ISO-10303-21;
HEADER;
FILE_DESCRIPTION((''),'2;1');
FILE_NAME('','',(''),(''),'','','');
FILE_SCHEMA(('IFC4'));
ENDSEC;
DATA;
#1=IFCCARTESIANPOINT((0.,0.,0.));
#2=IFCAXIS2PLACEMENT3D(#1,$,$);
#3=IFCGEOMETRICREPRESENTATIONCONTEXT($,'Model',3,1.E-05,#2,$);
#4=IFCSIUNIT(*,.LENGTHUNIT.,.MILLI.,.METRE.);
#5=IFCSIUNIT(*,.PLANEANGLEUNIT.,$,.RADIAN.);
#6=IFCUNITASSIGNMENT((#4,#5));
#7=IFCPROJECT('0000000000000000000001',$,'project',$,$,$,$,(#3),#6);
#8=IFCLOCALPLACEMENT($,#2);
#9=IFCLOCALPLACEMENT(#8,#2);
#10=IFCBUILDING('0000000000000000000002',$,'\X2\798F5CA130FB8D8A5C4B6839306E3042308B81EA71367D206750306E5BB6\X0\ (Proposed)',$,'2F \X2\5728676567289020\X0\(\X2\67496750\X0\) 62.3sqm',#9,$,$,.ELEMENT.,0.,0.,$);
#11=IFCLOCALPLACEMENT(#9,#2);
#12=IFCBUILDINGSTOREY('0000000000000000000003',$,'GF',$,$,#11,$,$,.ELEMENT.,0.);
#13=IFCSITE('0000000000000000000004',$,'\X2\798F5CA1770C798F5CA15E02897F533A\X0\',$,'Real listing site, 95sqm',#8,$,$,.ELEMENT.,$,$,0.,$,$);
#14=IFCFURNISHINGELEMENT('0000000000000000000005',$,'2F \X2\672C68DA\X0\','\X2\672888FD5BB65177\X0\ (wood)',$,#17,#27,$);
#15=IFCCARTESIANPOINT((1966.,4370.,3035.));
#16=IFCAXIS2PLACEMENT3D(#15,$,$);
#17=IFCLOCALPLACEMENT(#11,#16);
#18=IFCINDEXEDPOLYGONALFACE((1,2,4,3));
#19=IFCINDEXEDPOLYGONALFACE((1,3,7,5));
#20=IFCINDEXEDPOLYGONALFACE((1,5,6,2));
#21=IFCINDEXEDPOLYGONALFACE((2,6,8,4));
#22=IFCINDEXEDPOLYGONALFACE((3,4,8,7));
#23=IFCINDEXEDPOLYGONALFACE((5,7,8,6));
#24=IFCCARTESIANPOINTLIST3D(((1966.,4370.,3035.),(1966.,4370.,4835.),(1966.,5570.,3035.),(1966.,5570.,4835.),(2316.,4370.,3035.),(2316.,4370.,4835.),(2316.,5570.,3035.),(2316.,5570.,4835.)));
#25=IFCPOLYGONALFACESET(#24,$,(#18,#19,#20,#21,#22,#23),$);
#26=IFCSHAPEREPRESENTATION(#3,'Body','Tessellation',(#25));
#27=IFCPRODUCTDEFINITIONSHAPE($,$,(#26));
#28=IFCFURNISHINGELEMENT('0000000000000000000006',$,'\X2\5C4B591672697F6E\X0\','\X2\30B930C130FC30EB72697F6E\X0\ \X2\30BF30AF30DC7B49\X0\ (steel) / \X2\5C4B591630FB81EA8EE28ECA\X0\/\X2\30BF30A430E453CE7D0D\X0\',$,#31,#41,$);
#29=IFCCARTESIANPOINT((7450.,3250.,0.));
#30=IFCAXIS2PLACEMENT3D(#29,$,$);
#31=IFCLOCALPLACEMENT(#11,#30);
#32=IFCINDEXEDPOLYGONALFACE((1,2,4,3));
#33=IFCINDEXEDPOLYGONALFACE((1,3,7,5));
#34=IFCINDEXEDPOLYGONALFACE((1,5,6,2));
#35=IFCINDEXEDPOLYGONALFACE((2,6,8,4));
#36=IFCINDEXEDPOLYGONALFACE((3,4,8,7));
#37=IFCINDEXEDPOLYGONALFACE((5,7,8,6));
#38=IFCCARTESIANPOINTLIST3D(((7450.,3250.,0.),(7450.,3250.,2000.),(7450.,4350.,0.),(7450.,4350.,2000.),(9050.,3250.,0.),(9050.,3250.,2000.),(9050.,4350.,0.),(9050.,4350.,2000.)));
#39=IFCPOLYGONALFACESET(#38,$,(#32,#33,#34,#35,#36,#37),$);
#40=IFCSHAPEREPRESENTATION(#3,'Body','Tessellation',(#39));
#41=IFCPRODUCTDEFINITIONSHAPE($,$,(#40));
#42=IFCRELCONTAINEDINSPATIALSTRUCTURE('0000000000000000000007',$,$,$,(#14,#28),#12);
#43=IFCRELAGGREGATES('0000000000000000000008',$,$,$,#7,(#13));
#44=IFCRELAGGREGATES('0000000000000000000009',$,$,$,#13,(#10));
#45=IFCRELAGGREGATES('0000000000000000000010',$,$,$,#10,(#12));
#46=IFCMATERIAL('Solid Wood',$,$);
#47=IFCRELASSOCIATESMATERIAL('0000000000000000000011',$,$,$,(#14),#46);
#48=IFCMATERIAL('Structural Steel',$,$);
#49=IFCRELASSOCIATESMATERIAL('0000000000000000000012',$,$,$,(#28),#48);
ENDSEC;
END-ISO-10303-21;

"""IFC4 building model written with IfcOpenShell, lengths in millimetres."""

from ifc_helpers import new_model, si_unit, frame, frame_2d, origin, place, context, project, spatial, rectangle, extrude, material, element, save


model = new_model("IFC4")

# Units and contexts
model_context = context("Model", 3, precision=1e-05, world=origin())
ifc_project = project(units=[si_unit("LENGTHUNIT", "METRE", prefix="MILLI"), si_unit("PLANEANGLEUNIT", "RADIAN")], contexts=[model_context])

# Site, building, storey
site_placement = place(None, origin())
site = spatial("IfcSite", under=ifc_project, at=site_placement, Name="福岡県福岡市西区", ObjectType="Real listing site, 95sqm", CompositionType="ELEMENT", RefElevation=0.0)
building_placement = place(site_placement, origin())
building = spatial("IfcBuilding", under=site, at=building_placement, Name="福岡・越屋根のある自然素材の家 (Proposed)", ObjectType="2F 在来木造(杉材) 62.3sqm", CompositionType="ELEMENT", ElevationOfRefHeight=0.0, ElevationOfTerrain=0.0)
storey_placement = place(building_placement, origin())
storey = spatial("IfcBuildingStorey", under=building, at=storey_placement, Name="GF", CompositionType="ELEMENT", Elevation=0.0)

# Shared definitions
ifc_material_1 = material(Name="Solid Wood")

# Shared definitions
ifc_material_2 = material(Name="Structural Steel")

# Furnishing elements
furnishing_1_placement = place(storey_placement, frame((1966.0, 4370.0, 3035.0)))
element("IfcFurnishingElement", 1, at=furnishing_1_placement, inside=storey, material=ifc_material_1, Name="2F 本棚", Description="木製家具 (wood)", context=model_context, shape_type="SweptSolid", body=[
    extrude(rectangle(XDim=350.0, YDim=1200.0, at=frame_2d((175.0, 600.0))), frame((1966.0, 4370.0, 3035.0)), (0.0, 0.0, 1.0), 1800.0),
])
furnishing_2_placement = place(storey_placement, frame((7450.0, 3250.0, 0.0)))
element("IfcFurnishingElement", 2, at=furnishing_2_placement, inside=storey, material=ifc_material_2, Name="屋外物置", Description="スチール物置 タクボ等 (steel) / 屋外・自転車/タイヤ収納", context=model_context, shape_type="SweptSolid", body=[
    extrude(rectangle(XDim=1600.0, YDim=1100.0, at=frame_2d((800.0, 550.0))), frame((7450.0, 3250.0, 0.0)), (0.0, 0.0, 1.0), 2000.0),
])

save(model, "model.ifc")
